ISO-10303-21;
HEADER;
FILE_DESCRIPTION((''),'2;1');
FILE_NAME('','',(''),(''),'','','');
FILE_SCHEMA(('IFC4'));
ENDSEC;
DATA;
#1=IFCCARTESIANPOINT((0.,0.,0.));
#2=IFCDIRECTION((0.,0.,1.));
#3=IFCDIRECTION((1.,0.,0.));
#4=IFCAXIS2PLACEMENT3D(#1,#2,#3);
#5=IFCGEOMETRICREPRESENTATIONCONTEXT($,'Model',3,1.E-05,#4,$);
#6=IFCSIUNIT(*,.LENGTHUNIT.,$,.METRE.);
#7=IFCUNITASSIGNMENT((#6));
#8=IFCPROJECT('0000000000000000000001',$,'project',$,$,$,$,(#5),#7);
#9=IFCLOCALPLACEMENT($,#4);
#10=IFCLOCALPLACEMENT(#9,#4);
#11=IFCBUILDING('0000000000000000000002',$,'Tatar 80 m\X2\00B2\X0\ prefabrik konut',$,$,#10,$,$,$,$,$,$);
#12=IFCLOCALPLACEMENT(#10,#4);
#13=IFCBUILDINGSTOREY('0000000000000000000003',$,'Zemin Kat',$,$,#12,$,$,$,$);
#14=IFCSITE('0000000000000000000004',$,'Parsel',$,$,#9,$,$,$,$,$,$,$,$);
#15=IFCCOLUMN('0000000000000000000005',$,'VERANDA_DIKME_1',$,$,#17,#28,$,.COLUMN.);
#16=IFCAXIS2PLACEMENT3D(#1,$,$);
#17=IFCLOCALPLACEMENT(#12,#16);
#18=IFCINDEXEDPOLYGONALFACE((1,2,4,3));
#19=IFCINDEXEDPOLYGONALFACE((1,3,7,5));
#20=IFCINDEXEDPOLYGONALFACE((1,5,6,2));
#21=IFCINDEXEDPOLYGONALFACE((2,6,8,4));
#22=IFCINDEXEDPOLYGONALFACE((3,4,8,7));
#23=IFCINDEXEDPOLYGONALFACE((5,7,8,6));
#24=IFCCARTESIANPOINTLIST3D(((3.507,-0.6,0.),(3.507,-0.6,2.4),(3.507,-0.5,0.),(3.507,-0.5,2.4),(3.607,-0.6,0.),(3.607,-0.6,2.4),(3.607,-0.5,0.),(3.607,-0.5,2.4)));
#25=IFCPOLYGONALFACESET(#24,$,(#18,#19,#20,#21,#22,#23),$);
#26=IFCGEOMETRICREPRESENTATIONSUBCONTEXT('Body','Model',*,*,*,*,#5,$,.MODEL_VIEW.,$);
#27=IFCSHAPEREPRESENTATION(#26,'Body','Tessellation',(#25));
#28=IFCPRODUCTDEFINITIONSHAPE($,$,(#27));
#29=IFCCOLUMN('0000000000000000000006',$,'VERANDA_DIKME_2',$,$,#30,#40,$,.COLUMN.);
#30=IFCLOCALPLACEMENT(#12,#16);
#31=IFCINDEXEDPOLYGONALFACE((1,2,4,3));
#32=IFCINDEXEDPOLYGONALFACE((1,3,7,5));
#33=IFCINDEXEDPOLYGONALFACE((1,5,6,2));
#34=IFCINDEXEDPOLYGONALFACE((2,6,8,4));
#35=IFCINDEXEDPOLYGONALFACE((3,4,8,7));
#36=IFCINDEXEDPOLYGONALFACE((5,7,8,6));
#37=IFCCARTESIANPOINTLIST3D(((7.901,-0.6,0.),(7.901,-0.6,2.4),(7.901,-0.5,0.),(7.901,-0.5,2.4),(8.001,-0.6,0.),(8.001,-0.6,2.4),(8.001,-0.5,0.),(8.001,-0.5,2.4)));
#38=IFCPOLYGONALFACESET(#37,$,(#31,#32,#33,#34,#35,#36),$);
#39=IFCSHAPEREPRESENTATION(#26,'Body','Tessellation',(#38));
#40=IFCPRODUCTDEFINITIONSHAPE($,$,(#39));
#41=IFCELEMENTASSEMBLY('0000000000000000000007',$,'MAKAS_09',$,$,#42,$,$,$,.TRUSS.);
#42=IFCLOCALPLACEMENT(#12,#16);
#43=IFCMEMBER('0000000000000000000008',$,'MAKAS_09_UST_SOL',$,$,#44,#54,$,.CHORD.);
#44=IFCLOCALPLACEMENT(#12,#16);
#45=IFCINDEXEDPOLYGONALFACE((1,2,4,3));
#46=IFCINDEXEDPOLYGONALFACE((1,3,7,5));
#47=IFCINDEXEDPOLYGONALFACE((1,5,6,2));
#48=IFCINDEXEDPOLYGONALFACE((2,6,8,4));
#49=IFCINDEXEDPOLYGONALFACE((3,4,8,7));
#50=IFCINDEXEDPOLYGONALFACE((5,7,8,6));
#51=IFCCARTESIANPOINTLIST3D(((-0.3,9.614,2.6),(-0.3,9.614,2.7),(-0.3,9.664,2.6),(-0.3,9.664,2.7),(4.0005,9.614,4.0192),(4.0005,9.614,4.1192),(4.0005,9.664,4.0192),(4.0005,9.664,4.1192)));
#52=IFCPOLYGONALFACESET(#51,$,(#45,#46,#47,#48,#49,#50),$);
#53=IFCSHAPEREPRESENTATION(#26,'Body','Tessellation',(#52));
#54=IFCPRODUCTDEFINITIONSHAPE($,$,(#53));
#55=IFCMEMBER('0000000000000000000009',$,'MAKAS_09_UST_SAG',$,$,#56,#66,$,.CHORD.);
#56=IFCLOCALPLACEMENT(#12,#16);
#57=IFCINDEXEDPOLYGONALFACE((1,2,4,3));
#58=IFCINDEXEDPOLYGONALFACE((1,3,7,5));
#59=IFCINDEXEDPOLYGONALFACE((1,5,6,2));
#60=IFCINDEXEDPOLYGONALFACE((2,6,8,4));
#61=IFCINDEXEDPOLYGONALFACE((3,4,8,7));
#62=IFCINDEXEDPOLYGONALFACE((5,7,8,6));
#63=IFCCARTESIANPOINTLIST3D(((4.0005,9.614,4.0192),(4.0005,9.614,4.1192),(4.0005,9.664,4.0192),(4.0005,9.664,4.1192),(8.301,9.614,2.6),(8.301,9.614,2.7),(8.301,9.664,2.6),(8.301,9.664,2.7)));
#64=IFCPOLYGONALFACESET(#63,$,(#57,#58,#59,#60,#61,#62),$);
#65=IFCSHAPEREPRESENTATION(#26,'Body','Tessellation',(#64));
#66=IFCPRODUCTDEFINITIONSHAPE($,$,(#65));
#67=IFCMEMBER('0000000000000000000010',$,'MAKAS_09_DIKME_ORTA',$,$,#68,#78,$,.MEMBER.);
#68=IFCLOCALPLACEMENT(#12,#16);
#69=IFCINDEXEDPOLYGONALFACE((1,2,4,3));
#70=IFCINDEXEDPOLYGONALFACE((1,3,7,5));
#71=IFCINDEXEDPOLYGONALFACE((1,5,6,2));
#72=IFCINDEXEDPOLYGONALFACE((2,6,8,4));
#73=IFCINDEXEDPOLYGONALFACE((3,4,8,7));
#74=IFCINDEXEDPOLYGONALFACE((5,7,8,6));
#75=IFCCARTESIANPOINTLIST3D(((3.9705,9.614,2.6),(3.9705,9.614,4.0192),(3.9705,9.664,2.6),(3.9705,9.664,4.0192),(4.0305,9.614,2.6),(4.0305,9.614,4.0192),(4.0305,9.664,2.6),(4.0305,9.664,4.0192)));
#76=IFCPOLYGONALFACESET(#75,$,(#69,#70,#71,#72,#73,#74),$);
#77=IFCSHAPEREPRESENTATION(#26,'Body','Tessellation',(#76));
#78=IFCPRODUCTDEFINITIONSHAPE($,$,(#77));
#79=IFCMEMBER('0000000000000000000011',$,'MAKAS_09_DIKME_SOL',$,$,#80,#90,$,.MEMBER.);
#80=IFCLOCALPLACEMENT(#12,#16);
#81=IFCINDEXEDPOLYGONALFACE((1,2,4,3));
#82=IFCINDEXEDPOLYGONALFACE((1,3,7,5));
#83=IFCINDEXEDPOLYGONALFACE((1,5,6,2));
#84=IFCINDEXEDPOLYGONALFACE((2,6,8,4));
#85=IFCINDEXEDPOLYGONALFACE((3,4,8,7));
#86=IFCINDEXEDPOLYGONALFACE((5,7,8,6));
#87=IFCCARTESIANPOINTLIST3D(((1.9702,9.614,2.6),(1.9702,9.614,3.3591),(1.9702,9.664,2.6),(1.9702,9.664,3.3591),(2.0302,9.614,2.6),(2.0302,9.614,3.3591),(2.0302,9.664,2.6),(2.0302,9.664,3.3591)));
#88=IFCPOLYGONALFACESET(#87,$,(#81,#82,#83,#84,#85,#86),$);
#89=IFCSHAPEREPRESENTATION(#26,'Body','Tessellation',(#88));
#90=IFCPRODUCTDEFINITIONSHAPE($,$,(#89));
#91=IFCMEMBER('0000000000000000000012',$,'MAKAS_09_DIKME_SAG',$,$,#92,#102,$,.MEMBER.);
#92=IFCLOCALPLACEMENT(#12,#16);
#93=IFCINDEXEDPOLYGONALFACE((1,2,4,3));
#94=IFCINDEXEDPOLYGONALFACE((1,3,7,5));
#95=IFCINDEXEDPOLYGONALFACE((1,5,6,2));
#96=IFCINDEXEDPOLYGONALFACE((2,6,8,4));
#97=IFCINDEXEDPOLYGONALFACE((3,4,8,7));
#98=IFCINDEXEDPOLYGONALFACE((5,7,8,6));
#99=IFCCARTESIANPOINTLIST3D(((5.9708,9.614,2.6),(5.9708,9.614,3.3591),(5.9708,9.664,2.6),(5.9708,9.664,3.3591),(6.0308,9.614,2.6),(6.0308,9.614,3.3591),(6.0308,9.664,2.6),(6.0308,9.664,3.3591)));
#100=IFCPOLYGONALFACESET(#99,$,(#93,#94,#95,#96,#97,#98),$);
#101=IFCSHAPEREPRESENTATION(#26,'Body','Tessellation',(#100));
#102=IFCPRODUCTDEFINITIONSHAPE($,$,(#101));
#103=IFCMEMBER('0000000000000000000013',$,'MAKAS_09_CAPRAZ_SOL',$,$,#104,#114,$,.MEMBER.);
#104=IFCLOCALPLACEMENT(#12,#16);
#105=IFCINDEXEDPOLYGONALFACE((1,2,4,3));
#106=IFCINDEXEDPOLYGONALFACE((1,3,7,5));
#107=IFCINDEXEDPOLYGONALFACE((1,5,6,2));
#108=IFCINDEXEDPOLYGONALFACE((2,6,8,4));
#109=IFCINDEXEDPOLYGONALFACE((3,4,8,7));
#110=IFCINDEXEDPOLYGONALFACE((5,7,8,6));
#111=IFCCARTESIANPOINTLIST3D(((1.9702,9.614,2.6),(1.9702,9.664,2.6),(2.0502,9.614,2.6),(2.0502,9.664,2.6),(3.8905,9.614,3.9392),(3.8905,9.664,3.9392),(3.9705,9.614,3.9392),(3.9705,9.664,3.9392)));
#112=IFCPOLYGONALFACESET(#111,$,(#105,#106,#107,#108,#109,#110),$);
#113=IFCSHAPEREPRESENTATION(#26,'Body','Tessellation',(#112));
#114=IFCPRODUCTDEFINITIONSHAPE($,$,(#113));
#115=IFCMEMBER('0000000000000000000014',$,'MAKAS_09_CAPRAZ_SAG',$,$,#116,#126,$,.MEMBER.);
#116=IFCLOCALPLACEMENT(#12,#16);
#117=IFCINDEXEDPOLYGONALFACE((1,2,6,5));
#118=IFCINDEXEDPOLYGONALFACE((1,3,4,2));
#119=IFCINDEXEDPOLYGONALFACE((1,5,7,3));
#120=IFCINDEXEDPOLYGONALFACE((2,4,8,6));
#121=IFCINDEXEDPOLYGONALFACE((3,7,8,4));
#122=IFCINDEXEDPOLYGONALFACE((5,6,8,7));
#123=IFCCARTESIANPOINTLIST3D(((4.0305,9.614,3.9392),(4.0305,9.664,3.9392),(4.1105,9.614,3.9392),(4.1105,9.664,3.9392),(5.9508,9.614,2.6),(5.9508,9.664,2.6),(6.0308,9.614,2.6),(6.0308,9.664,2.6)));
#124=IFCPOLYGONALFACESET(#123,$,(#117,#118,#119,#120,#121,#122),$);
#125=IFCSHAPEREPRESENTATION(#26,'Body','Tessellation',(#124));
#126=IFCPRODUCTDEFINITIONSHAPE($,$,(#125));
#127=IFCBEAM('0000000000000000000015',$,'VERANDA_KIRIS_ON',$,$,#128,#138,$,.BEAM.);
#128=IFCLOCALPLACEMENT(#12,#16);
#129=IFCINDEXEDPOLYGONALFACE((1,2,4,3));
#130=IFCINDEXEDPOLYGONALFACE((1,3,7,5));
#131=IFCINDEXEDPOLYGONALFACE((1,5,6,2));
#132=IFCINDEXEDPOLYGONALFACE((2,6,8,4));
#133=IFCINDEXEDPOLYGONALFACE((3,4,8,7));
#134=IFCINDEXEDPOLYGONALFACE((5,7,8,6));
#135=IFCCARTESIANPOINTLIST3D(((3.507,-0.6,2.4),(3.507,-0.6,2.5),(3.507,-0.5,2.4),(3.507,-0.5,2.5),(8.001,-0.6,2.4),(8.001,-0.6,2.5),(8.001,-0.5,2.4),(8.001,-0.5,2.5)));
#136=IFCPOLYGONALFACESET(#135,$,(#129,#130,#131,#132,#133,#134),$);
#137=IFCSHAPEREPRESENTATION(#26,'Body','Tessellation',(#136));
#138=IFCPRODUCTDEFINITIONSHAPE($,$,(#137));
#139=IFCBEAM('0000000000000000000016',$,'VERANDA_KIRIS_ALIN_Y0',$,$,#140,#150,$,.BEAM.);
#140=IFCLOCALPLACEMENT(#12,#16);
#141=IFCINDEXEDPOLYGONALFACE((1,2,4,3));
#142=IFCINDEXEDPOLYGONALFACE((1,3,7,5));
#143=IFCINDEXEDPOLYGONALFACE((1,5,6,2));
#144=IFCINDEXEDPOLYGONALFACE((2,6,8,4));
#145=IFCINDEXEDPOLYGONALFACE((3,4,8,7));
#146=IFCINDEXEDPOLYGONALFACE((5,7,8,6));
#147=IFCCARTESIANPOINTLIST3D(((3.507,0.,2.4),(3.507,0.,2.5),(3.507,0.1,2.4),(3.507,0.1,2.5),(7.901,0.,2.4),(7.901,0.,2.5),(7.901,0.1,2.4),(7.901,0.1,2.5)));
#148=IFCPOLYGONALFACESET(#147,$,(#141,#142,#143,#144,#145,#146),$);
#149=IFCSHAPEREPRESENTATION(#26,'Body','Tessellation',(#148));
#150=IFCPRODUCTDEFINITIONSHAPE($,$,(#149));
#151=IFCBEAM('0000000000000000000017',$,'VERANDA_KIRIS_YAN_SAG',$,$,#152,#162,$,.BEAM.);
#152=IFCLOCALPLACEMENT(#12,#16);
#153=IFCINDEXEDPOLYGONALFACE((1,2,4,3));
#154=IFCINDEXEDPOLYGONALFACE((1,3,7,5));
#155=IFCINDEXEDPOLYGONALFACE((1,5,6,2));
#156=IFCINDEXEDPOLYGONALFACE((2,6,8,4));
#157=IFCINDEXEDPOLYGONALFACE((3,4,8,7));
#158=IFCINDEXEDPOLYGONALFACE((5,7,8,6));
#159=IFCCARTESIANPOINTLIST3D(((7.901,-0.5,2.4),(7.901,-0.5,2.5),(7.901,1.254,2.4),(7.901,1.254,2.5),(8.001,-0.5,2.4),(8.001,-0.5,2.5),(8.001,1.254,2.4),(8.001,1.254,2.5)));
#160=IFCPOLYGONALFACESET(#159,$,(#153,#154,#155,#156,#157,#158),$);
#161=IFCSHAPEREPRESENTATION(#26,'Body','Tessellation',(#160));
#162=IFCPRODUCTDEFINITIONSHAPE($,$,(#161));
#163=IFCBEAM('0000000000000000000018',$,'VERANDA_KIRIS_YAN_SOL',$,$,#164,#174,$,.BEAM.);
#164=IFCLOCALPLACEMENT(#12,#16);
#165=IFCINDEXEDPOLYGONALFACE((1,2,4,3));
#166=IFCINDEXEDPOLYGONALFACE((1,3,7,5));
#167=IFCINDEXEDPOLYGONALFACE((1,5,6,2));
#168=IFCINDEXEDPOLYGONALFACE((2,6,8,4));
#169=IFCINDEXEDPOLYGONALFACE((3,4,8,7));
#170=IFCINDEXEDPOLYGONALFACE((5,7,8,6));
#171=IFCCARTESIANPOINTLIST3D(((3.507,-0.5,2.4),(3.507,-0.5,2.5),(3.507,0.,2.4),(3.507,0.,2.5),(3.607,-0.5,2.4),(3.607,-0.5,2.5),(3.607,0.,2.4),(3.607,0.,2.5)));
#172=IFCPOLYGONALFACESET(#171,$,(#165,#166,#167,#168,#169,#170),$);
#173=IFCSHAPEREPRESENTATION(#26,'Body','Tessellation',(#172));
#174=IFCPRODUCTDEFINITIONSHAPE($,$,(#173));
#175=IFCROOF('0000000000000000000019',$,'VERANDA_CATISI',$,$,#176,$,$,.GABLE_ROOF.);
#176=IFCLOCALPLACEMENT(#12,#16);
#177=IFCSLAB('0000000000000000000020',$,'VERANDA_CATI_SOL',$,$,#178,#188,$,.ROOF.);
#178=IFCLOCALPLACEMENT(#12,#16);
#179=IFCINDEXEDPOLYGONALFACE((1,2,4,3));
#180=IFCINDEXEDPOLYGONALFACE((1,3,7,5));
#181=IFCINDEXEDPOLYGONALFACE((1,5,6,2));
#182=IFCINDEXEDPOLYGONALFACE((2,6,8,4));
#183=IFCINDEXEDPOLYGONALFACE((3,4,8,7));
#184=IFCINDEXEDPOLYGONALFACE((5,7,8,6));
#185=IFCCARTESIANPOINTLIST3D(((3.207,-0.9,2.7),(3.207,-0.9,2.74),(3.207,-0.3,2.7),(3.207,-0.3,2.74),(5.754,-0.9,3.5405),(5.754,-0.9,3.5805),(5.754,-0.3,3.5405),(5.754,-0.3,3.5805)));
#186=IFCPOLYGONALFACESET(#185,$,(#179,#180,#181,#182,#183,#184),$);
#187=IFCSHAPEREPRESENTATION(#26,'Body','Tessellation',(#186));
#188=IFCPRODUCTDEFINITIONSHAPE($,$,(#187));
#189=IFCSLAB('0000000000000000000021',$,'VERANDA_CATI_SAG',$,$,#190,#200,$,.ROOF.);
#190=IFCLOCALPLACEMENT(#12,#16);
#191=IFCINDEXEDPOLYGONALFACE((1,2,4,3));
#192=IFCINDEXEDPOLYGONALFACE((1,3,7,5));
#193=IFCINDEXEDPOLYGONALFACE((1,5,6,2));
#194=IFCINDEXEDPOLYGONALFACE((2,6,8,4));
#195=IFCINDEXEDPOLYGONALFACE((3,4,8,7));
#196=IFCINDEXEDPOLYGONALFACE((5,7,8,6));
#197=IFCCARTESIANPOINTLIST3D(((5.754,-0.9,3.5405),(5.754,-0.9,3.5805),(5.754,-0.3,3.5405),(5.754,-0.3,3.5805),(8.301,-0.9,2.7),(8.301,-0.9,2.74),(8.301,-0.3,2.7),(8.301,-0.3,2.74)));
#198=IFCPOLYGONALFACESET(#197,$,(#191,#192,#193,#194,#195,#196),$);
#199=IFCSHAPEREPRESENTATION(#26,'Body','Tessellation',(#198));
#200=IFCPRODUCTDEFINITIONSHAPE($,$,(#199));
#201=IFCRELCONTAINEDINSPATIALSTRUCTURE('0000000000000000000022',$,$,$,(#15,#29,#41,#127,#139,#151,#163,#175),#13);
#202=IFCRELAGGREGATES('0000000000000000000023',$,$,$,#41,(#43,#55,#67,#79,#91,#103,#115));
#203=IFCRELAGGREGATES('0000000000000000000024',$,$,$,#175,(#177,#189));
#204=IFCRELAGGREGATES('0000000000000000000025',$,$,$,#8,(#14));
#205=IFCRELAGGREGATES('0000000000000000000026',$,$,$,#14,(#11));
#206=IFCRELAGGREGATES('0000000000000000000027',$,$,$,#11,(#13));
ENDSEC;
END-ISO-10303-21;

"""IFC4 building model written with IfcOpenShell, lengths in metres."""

from ifc_helpers import new_model, si_unit, frame, origin_with_axes, place, context, subcontext, project, spatial, line, indexed_curve, outline, extrude, element, aggregate, save


model = new_model("IFC4")

# Units and contexts
model_context = context("Model", 3, precision=1e-05, world=origin_with_axes())
body_context = subcontext(model_context, "Body", "Model", "MODEL_VIEW")
ifc_project = project(units=[si_unit("LENGTHUNIT", "METRE")], contexts=[model_context])

# Site, building, storey
site_placement = place(None, origin_with_axes())
site = spatial("IfcSite", under=ifc_project, at=site_placement, Name="Parsel")
building_placement = place(site_placement, origin_with_axes())
building = spatial("IfcBuilding", under=site, at=building_placement, Name="Tatar 80 m² prefabrik konut")
storey_placement = place(building_placement, origin_with_axes())
storey = spatial("IfcBuildingStorey", under=building, at=storey_placement, Name="Zemin Kat")

# Columns
column_1_placement = place(storey_placement, origin_with_axes())
element("IfcColumn", 1, at=column_1_placement, inside=storey, Name="VERANDA_DIKME_1", PredefinedType="COLUMN", context=body_context, shape_type="SweptSolid", body=[
    extrude(outline(indexed_curve([(3.507, -0.6), (3.607, -0.6), (3.607, -0.5), (3.507, -0.5)], segments=[line(1, 2, 3, 4, 1)])), origin_with_axes(), (0.0, 0.0, 1.0), 2.4),
])
column_2_placement = place(storey_placement, origin_with_axes())
element("IfcColumn", 2, at=column_2_placement, inside=storey, Name="VERANDA_DIKME_2", PredefinedType="COLUMN", context=body_context, shape_type="SweptSolid", body=[
    extrude(outline(indexed_curve([(7.901, -0.6), (8.001, -0.6), (8.001, -0.5), (7.901, -0.5)], segments=[line(1, 2, 3, 4, 1)])), origin_with_axes(), (0.0, 0.0, 1.0), 2.4),
])

# Element assembly, members
assembly_placement = place(storey_placement, origin_with_axes())
assembly = element("IfcElementAssembly", 3, at=assembly_placement, inside=storey, Name="MAKAS_09", PredefinedType="TRUSS")
member_1_placement = place(assembly_placement, origin_with_axes())
member_1 = element("IfcMember", 4, at=member_1_placement, Name="MAKAS_09_UST_SOL", PredefinedType="CHORD", context=body_context, shape_type="SweptSolid", body=[
    extrude(outline(indexed_curve([(-0.3, 2.6), (4.0005, 4.0192), (4.0005, 4.1192), (-0.3, 2.7)], segments=[line(1, 2, 3, 4, 1)])), frame((0.0, 9.664, 0.0), z_axis=(0.0, -1.0, 0.0), x_axis=(1.0, 0.0, 0.0)), (0.0, 0.0, 1.0), 0.05),
])
member_2_placement = place(assembly_placement, origin_with_axes())
member_2 = element("IfcMember", 5, at=member_2_placement, Name="MAKAS_09_UST_SAG", PredefinedType="CHORD", context=body_context, shape_type="SweptSolid", body=[
    extrude(outline(indexed_curve([(4.0005, 4.0192), (8.301, 2.6), (8.301, 2.7), (4.0005, 4.1192)], segments=[line(1, 2, 3, 4, 1)])), frame((0.0, 9.664, 0.0), z_axis=(0.0, -1.0, 0.0), x_axis=(1.0, 0.0, 0.0)), (0.0, 0.0, 1.0), 0.05),
])
member_3_placement = place(assembly_placement, origin_with_axes())
member_3 = element("IfcMember", 6, at=member_3_placement, Name="MAKAS_09_DIKME_ORTA", PredefinedType="MEMBER", context=body_context, shape_type="SweptSolid", body=[
    extrude(outline(indexed_curve([(3.9705, 2.6), (4.0305, 2.6), (4.0305, 4.0192), (3.9705, 4.0192)], segments=[line(1, 2, 3, 4, 1)])), frame((0.0, 9.664, 0.0), z_axis=(0.0, -1.0, 0.0), x_axis=(1.0, 0.0, 0.0)), (0.0, 0.0, 1.0), 0.05),
])
member_4_placement = place(assembly_placement, origin_with_axes())
member_4 = element("IfcMember", 7, at=member_4_placement, Name="MAKAS_09_DIKME_SOL", PredefinedType="MEMBER", context=body_context, shape_type="SweptSolid", body=[
    extrude(outline(indexed_curve([(1.9703, 2.6), (2.0303, 2.6), (2.0303, 3.3591), (1.9703, 3.3591)], segments=[line(1, 2, 3, 4, 1)])), frame((0.0, 9.664, 0.0), z_axis=(0.0, -1.0, 0.0), x_axis=(1.0, 0.0, 0.0)), (0.0, 0.0, 1.0), 0.05),
])
member_5_placement = place(assembly_placement, origin_with_axes())
member_5 = element("IfcMember", 8, at=member_5_placement, Name="MAKAS_09_DIKME_SAG", PredefinedType="MEMBER", context=body_context, shape_type="SweptSolid", body=[
    extrude(outline(indexed_curve([(5.9708, 2.6), (6.0308, 2.6), (6.0308, 3.3591), (5.9708, 3.3591)], segments=[line(1, 2, 3, 4, 1)])), frame((0.0, 9.664, 0.0), z_axis=(0.0, -1.0, 0.0), x_axis=(1.0, 0.0, 0.0)), (0.0, 0.0, 1.0), 0.05),
])
member_6_placement = place(assembly_placement, origin_with_axes())
member_6 = element("IfcMember", 9, at=member_6_placement, Name="MAKAS_09_CAPRAZ_SOL", PredefinedType="MEMBER", context=body_context, shape_type="SweptSolid", body=[
    extrude(outline(indexed_curve([(1.9703, 2.6), (2.0503, 2.6), (3.9705, 3.9392), (3.8905, 3.9392)], segments=[line(1, 2, 3, 4, 1)])), frame((0.0, 9.664, 0.0), z_axis=(0.0, -1.0, 0.0), x_axis=(1.0, 0.0, 0.0)), (0.0, 0.0, 1.0), 0.05),
])
member_7_placement = place(assembly_placement, origin_with_axes())
member_7 = element("IfcMember", 10, at=member_7_placement, Name="MAKAS_09_CAPRAZ_SAG", PredefinedType="MEMBER", context=body_context, shape_type="SweptSolid", body=[
    extrude(outline(indexed_curve([(5.9508, 2.6), (6.0308, 2.6), (4.1105, 3.9392), (4.0305, 3.9392)], segments=[line(1, 2, 3, 4, 1)])), frame((0.0, 9.664, 0.0), z_axis=(0.0, -1.0, 0.0), x_axis=(1.0, 0.0, 0.0)), (0.0, 0.0, 1.0), 0.05),
])
aggregate(assembly, [member_1, member_2, member_3, member_4, member_5, member_6, member_7])

# Beams
beam_1_placement = place(storey_placement, origin_with_axes())
element("IfcBeam", 11, at=beam_1_placement, inside=storey, Name="VERANDA_KIRIS_ON", PredefinedType="BEAM", context=body_context, shape_type="SweptSolid", body=[
    extrude(outline(indexed_curve([(3.507, -0.6), (8.001, -0.6), (8.001, -0.5), (3.507, -0.5)], segments=[line(1, 2, 3, 4, 1)])), frame((0.0, 0.0, 2.4), z_axis=(0.0, 0.0, 1.0), x_axis=(1.0, 0.0, 0.0)), (0.0, 0.0, 1.0), 0.1),
])
beam_2_placement = place(storey_placement, origin_with_axes())
element("IfcBeam", 12, at=beam_2_placement, inside=storey, Name="VERANDA_KIRIS_ALIN_Y0", PredefinedType="BEAM", context=body_context, shape_type="SweptSolid", body=[
    extrude(outline(indexed_curve([(3.507, 0.0), (7.901, 0.0), (7.901, 0.1), (3.507, 0.1)], segments=[line(1, 2, 3, 4, 1)])), frame((0.0, 0.0, 2.4), z_axis=(0.0, 0.0, 1.0), x_axis=(1.0, 0.0, 0.0)), (0.0, 0.0, 1.0), 0.1),
])
beam_3_placement = place(storey_placement, origin_with_axes())
element("IfcBeam", 13, at=beam_3_placement, inside=storey, Name="VERANDA_KIRIS_YAN_SAG", PredefinedType="BEAM", context=body_context, shape_type="SweptSolid", body=[
    extrude(outline(indexed_curve([(7.901, -0.5), (8.001, -0.5), (8.001, 1.254), (7.901, 1.254)], segments=[line(1, 2, 3, 4, 1)])), frame((0.0, 0.0, 2.4), z_axis=(0.0, 0.0, 1.0), x_axis=(1.0, 0.0, 0.0)), (0.0, 0.0, 1.0), 0.1),
])
beam_4_placement = place(storey_placement, origin_with_axes())
element("IfcBeam", 14, at=beam_4_placement, inside=storey, Name="VERANDA_KIRIS_YAN_SOL", PredefinedType="BEAM", context=body_context, shape_type="SweptSolid", body=[
    extrude(outline(indexed_curve([(3.507, -0.5), (3.607, -0.5), (3.607, 0.0), (3.507, 0.0)], segments=[line(1, 2, 3, 4, 1)])), frame((0.0, 0.0, 2.4), z_axis=(0.0, 0.0, 1.0), x_axis=(1.0, 0.0, 0.0)), (0.0, 0.0, 1.0), 0.1),
])

# Roof, slabs
roof_placement = place(storey_placement, origin_with_axes())
roof = element("IfcRoof", 15, at=roof_placement, inside=storey, Name="VERANDA_CATISI", PredefinedType="GABLE_ROOF")
slab_1_placement = place(roof_placement, origin_with_axes())
slab_1 = element("IfcSlab", 16, at=slab_1_placement, Name="VERANDA_CATI_SOL", PredefinedType="ROOF", context=body_context, shape_type="SweptSolid", body=[
    extrude(outline(indexed_curve([(3.207, 2.7), (5.754, 3.5405), (5.754, 3.5805), (3.207, 2.74)], segments=[line(1, 2, 3, 4, 1)])), frame((0.0, -0.3, 0.0), z_axis=(0.0, -1.0, 0.0), x_axis=(1.0, 0.0, 0.0)), (0.0, 0.0, 1.0), 0.6),
])
slab_2_placement = place(roof_placement, origin_with_axes())
slab_2 = element("IfcSlab", 17, at=slab_2_placement, Name="VERANDA_CATI_SAG", PredefinedType="ROOF", context=body_context, shape_type="SweptSolid", body=[
    extrude(outline(indexed_curve([(5.754, 3.5405), (8.301, 2.7), (8.301, 2.74), (5.754, 3.5805)], segments=[line(1, 2, 3, 4, 1)])), frame((0.0, -0.3, 0.0), z_axis=(0.0, -1.0, 0.0), x_axis=(1.0, 0.0, 0.0)), (0.0, 0.0, 1.0), 0.6),
])
aggregate(roof, [slab_1, slab_2])

save(model, "model.ifc")
